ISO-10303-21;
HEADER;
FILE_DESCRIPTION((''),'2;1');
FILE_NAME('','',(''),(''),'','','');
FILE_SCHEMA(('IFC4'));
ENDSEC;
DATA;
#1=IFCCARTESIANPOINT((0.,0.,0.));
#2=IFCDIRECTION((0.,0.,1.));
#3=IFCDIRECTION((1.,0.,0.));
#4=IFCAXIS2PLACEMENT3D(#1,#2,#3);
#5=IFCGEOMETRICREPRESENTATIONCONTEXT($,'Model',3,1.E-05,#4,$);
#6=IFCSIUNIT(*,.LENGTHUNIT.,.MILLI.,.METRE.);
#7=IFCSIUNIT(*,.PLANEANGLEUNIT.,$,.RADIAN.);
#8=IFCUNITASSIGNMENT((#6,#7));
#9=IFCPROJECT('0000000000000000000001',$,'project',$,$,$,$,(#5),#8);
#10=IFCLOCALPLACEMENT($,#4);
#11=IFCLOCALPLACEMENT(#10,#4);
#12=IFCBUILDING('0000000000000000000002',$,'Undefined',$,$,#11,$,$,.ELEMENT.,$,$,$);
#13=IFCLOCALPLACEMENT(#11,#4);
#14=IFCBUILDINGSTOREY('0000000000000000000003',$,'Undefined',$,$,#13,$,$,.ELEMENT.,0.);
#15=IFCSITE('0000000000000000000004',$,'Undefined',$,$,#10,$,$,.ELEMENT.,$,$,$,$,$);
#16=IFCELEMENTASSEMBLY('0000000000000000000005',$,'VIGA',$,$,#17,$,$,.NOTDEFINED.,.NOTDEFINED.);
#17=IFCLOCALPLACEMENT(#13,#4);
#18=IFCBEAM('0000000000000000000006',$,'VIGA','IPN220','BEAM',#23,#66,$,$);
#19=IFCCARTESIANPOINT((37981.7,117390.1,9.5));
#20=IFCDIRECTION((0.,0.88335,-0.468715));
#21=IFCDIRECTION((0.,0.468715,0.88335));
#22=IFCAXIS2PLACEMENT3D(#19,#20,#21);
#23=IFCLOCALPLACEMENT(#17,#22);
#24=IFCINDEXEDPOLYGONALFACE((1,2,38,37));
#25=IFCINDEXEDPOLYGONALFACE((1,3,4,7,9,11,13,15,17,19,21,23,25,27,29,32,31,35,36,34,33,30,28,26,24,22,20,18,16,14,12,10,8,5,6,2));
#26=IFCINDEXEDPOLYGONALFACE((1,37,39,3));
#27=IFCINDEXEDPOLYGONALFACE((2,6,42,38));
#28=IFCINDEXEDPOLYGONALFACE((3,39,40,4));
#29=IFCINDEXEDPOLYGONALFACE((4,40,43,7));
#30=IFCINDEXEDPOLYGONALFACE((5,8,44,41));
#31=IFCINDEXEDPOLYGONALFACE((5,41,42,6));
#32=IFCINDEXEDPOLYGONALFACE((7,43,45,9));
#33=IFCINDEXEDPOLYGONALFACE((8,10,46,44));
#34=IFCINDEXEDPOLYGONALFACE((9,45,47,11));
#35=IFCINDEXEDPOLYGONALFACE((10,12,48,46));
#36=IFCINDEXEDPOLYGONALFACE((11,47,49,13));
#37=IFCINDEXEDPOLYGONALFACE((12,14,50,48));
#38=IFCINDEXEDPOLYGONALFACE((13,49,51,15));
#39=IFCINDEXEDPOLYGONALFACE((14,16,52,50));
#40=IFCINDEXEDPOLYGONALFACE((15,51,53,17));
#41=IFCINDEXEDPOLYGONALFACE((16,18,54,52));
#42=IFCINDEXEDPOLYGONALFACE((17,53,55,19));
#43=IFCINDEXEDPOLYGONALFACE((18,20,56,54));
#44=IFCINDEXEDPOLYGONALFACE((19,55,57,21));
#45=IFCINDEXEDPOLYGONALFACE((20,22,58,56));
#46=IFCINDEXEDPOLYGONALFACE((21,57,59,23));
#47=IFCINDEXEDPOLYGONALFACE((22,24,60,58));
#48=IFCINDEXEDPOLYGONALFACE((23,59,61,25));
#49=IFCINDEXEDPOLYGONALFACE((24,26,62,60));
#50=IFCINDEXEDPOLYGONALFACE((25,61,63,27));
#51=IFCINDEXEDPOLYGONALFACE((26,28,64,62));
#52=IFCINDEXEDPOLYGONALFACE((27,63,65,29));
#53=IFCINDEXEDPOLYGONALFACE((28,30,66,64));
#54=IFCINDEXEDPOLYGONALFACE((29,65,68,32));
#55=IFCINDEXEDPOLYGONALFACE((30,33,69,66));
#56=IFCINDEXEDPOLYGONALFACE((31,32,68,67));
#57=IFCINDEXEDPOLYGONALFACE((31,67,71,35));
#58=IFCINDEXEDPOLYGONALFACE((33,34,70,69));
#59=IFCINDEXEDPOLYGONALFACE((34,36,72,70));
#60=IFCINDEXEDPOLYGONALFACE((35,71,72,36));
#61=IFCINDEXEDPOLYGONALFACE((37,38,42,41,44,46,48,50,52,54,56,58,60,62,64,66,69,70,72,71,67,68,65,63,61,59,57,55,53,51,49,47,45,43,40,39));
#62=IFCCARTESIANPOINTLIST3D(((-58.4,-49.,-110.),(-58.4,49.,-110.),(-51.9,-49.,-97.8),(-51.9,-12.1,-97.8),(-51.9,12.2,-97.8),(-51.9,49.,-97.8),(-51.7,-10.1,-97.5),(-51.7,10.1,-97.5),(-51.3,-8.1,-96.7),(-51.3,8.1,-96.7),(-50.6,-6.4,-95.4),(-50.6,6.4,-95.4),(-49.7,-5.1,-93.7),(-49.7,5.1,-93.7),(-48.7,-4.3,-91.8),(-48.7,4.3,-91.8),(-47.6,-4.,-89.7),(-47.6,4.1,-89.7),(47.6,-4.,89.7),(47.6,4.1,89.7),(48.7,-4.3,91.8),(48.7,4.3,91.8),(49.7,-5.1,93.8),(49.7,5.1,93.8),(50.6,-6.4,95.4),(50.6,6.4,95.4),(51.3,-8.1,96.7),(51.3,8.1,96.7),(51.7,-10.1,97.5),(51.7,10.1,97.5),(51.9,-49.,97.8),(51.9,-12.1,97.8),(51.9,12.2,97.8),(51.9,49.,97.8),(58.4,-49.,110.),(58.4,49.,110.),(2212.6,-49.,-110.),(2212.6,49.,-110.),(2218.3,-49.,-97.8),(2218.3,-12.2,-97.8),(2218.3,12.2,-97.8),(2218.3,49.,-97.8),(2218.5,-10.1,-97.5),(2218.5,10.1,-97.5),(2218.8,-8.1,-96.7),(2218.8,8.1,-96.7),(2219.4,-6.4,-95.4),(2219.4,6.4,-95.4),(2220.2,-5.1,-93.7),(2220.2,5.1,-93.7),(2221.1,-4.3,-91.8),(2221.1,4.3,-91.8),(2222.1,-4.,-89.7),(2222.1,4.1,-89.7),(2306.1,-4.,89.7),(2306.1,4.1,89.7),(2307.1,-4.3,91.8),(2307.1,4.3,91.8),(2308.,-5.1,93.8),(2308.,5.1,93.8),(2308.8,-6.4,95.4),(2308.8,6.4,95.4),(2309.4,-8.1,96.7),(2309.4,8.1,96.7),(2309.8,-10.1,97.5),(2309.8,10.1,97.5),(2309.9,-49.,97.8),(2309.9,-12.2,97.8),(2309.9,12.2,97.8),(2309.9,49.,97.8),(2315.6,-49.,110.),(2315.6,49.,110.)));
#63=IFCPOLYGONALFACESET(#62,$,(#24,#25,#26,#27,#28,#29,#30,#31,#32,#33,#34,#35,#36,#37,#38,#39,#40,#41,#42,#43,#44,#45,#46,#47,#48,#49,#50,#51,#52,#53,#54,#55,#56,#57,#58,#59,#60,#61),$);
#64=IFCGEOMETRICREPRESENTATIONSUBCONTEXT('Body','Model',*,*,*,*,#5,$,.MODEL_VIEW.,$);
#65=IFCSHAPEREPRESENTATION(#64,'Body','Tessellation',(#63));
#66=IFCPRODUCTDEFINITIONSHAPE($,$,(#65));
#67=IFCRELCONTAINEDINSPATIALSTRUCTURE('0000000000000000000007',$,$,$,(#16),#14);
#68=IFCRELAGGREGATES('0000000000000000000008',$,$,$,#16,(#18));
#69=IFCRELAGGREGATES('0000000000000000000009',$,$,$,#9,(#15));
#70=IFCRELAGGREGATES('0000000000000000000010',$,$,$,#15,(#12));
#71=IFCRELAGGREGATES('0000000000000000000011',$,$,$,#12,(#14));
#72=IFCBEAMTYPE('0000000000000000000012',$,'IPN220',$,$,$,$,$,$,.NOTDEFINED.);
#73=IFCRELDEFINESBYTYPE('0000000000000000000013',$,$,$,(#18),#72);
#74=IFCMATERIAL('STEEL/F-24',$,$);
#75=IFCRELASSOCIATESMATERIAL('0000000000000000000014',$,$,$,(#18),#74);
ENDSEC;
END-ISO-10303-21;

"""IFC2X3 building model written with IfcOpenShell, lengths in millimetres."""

from ifc_helpers import new_model, si_unit, frame, origin_with_axes, origin_2d_with_axis, place, context, subcontext, project, spatial, i_section, extrude, clip, halfspace, material, type_object, element, aggregate, save


model = new_model("IFC2X3")

# Units and contexts
model_context = context("Model", 3, precision=1e-05, world=origin_with_axes())
body_context = subcontext(model_context, "Body", "Model", "MODEL_VIEW")
ifc_project = project(units=[si_unit("LENGTHUNIT", "METRE", prefix="MILLI"), si_unit("PLANEANGLEUNIT", "RADIAN")], contexts=[model_context])

# Site, building, storey
site_placement = place(None, origin_with_axes())
site = spatial("IfcSite", under=ifc_project, at=site_placement, Name="Undefined", CompositionType="ELEMENT")
building_placement = place(site_placement, origin_with_axes())
building = spatial("IfcBuilding", under=site, at=building_placement, Name="Undefined", CompositionType="ELEMENT")
storey_placement = place(building_placement, origin_with_axes())
storey = spatial("IfcBuildingStorey", under=building, at=storey_placement, Name="Undefined", CompositionType="ELEMENT", Elevation=0.0)

# Element assembly, beam
assembly_1_placement = place(storey_placement, origin_with_axes())
assembly_1 = element("IfcElementAssembly", 1, at=assembly_1_placement, inside=storey, Name="VIGA", AssemblyPlace="NOTDEFINED", PredefinedType="NOTDEFINED")
ifc_material_1 = material(Name="STEEL/F-24")
beam_type_1 = type_object("IfcBeamType", Name="IPN220", PredefinedType="NOTDEFINED")
beam_1_placement = place(assembly_1_placement, frame((37981.7, 117390.1, 9.5), z_axis=(0.0, 0.88335, -0.468715), x_axis=(0.0, 0.468715, 0.88335)))
beam_1 = element("IfcBeam", 2, at=beam_1_placement, type_object=beam_type_1, material=ifc_material_1, Name="VIGA", Description="IPN220", ObjectType="BEAM", context=body_context, shape_type="Clipping", body=[
    clip(clip(extrude(i_section(OverallWidth=98.0, OverallDepth=220.0, WebThickness=8.1, FlangeThickness=12.2, FilletRadius=8.1, at=origin_2d_with_axis()), frame((2385.9, 0.0, 0.0), z_axis=(-1.0, 0.0, 0.0), x_axis=(0.0, -1.0, 0.0)), (0.0, 0.0, 1.0), 2507.7), halfspace(frame((2264.1, 0.0, 0.0), z_axis=(-0.905659, 0.0, 0.424006), x_axis=(0.424006, 0.0, 0.905659)), True)), halfspace(frame((0.0, 0.0, 0.0), z_axis=(-0.88335, 0.0, 0.468715), x_axis=(-0.468715, 0.0, -0.88335)), False)),
])

aggregate(assembly_1, [beam_1])

save(model, "model.ifc")
